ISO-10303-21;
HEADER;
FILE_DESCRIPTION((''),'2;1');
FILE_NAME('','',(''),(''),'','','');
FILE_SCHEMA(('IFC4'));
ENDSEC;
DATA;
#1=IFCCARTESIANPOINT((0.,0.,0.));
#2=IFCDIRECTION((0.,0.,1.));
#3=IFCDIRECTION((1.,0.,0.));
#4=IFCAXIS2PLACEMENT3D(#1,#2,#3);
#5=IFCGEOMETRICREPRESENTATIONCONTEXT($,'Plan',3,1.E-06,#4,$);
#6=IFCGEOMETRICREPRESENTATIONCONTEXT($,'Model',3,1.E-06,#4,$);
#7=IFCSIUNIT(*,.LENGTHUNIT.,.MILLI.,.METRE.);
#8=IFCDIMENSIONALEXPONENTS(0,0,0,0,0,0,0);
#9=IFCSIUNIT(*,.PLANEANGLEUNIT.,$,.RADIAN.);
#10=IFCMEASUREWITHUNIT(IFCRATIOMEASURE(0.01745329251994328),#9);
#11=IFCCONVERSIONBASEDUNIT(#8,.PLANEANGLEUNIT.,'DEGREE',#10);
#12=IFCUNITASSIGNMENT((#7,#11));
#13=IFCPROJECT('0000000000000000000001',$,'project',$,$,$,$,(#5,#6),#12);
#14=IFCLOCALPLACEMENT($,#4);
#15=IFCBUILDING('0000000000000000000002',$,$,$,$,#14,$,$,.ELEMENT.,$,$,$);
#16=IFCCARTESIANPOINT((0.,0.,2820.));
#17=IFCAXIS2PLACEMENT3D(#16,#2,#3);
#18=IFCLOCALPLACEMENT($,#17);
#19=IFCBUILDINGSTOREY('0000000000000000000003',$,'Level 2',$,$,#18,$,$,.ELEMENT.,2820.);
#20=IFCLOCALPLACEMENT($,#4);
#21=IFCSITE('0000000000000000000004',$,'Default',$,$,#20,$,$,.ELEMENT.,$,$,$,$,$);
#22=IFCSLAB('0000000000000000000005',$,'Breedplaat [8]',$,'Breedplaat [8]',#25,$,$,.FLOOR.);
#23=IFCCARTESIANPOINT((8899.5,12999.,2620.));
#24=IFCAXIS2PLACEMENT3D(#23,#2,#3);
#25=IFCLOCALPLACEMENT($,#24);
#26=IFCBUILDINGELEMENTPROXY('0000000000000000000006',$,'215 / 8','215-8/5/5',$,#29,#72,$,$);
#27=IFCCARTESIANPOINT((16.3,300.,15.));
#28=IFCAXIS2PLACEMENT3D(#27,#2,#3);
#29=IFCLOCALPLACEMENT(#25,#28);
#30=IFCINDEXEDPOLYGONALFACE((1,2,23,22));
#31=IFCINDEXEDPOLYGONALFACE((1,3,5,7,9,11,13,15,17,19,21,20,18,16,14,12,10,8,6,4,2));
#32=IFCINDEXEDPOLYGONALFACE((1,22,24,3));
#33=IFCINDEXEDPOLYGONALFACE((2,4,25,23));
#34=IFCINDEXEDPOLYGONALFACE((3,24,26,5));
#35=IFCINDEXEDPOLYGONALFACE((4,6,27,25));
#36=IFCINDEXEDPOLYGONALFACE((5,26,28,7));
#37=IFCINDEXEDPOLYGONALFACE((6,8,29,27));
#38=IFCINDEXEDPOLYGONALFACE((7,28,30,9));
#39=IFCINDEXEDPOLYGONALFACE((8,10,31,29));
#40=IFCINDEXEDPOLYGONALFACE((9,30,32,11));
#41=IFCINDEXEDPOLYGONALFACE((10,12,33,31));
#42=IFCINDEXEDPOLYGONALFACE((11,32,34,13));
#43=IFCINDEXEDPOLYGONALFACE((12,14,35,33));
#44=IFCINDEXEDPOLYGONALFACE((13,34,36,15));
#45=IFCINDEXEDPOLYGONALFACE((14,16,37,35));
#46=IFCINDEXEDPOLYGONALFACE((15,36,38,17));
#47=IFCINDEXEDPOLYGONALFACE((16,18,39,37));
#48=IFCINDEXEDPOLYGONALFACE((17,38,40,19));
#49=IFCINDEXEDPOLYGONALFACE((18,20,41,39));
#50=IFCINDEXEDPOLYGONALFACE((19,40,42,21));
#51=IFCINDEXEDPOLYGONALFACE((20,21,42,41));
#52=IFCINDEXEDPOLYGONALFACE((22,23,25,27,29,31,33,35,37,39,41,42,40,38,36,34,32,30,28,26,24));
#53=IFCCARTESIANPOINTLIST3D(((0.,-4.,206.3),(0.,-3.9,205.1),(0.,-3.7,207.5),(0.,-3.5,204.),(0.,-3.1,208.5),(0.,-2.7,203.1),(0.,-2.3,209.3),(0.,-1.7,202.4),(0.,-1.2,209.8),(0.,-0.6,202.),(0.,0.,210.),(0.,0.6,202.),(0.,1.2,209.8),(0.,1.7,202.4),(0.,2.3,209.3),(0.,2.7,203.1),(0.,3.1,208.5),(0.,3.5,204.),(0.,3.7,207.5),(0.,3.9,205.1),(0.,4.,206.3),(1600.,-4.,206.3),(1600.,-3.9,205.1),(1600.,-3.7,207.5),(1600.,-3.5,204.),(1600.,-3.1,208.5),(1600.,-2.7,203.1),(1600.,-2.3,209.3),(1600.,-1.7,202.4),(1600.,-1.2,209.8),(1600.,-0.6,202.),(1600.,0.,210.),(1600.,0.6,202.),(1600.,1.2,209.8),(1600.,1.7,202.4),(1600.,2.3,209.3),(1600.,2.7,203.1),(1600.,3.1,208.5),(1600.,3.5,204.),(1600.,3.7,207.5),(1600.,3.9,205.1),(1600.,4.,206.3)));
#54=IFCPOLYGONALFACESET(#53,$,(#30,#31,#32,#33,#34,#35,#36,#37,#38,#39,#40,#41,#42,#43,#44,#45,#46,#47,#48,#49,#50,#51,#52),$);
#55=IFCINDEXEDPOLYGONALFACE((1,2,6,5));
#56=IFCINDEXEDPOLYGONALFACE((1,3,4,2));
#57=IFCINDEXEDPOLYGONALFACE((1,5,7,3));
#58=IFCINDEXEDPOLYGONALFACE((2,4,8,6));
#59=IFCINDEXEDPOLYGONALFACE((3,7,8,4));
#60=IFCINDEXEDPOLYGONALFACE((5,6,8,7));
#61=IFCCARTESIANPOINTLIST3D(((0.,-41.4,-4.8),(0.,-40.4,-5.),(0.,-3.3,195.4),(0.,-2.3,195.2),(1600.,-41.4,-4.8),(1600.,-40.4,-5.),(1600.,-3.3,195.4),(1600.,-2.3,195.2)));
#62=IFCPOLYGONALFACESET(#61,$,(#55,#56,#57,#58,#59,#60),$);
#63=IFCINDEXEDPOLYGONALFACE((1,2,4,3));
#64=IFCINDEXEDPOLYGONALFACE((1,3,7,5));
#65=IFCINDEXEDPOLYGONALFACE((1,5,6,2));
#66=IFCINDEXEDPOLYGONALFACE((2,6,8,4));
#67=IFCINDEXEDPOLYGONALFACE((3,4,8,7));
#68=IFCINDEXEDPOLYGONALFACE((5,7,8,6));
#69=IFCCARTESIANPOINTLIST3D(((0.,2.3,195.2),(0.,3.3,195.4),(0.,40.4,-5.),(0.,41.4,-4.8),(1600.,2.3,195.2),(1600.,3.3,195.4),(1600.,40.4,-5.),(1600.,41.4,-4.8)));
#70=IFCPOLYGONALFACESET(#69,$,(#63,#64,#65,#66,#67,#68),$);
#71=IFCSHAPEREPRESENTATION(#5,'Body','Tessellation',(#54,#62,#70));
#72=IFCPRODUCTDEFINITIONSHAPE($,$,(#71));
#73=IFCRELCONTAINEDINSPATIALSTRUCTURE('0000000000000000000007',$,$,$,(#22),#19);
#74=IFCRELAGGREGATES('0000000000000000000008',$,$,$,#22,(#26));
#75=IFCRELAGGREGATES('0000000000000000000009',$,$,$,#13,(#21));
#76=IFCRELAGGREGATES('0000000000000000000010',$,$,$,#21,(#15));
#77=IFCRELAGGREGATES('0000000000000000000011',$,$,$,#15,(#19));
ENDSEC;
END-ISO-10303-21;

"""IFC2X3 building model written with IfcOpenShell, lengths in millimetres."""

from ifc_helpers import new_model, entity, si_unit, converted_unit, frame, origin_with_axes, origin_2d_with_axis, place, context, project, spatial, rectangle, circle, extrude, element, aggregate, save


model = new_model("IFC2X3")

# Units and contexts
plan_context = context("Plan", 3, precision=1e-06, world=origin_with_axes())
model_context = context("Model", 3, precision=1e-06, world=origin_with_axes())
ifc_project = project(units=[si_unit("LENGTHUNIT", "METRE", prefix="MILLI"), converted_unit("PLANEANGLEUNIT", "DEGREE", entity("IfcRatioMeasure", 0.01745329251994328), si_unit("PLANEANGLEUNIT", "RADIAN"), dimensions=[0, 0, 0, 0, 0, 0, 0])], contexts=[plan_context, model_context])

# Site, building, storey
site_placement = place(None, origin_with_axes())
site = spatial("IfcSite", under=ifc_project, at=site_placement, Name="Default", CompositionType="ELEMENT")
building_placement = place(None, origin_with_axes())
building = spatial("IfcBuilding", under=site, at=building_placement, CompositionType="ELEMENT")
storey_placement = place(None, frame((0.0, 0.0, 2820.0), z_axis=(0.0, 0.0, 1.0), x_axis=(1.0, 0.0, 0.0)))
storey = spatial("IfcBuildingStorey", under=building, at=storey_placement, Name="Level 2", CompositionType="ELEMENT", Elevation=2820.0)

# Slab, building element proxy
slab_1_placement = place(None, frame((8899.5, 12999.0, 2620.0), z_axis=(0.0, 0.0, 1.0), x_axis=(1.0, 0.0, 0.0)))
slab_1 = element("IfcSlab", 1, at=slab_1_placement, inside=storey, Name="Breedplaat [8]", ObjectType="Breedplaat [8]", PredefinedType="FLOOR")
proxy_1_placement = place(slab_1_placement, frame((16.3, 300.0, 15.0), z_axis=(0.0, 0.0, 1.0), x_axis=(1.0, 0.0, 0.0)))
proxy_1 = element("IfcBuildingElementProxy", 2, at=proxy_1_placement, Name="215 / 8", Description="215-8/5/5", context=plan_context, shape_type="SweptSolid", body=[
    extrude(circle(Radius=4.0, at=origin_2d_with_axis()), frame((0.0, 0.0, 206.0), z_axis=(1.0, 0.0, 0.0), x_axis=(0.0, 0.0, 1.0)), (0.0, 0.0, 1.0), 1600.0),
    extrude(rectangle(XDim=203.8, YDim=1.0, at=origin_2d_with_axis()), frame((0.0, -21.9, 95.2), z_axis=(1.0, 0.0, 0.0), x_axis=(0.0, 0.187112, 0.982339)), (0.0, 0.0, 1.0), 1600.0),
    extrude(rectangle(XDim=203.8, YDim=1.0, at=origin_2d_with_axis()), frame((0.0, 21.9, 95.2), z_axis=(1.0, 0.0, 0.0), x_axis=(0.0, -0.187112, 0.982339)), (0.0, 0.0, 1.0), 1600.0),
])
aggregate(slab_1, [proxy_1])

save(model, "model.ifc")
